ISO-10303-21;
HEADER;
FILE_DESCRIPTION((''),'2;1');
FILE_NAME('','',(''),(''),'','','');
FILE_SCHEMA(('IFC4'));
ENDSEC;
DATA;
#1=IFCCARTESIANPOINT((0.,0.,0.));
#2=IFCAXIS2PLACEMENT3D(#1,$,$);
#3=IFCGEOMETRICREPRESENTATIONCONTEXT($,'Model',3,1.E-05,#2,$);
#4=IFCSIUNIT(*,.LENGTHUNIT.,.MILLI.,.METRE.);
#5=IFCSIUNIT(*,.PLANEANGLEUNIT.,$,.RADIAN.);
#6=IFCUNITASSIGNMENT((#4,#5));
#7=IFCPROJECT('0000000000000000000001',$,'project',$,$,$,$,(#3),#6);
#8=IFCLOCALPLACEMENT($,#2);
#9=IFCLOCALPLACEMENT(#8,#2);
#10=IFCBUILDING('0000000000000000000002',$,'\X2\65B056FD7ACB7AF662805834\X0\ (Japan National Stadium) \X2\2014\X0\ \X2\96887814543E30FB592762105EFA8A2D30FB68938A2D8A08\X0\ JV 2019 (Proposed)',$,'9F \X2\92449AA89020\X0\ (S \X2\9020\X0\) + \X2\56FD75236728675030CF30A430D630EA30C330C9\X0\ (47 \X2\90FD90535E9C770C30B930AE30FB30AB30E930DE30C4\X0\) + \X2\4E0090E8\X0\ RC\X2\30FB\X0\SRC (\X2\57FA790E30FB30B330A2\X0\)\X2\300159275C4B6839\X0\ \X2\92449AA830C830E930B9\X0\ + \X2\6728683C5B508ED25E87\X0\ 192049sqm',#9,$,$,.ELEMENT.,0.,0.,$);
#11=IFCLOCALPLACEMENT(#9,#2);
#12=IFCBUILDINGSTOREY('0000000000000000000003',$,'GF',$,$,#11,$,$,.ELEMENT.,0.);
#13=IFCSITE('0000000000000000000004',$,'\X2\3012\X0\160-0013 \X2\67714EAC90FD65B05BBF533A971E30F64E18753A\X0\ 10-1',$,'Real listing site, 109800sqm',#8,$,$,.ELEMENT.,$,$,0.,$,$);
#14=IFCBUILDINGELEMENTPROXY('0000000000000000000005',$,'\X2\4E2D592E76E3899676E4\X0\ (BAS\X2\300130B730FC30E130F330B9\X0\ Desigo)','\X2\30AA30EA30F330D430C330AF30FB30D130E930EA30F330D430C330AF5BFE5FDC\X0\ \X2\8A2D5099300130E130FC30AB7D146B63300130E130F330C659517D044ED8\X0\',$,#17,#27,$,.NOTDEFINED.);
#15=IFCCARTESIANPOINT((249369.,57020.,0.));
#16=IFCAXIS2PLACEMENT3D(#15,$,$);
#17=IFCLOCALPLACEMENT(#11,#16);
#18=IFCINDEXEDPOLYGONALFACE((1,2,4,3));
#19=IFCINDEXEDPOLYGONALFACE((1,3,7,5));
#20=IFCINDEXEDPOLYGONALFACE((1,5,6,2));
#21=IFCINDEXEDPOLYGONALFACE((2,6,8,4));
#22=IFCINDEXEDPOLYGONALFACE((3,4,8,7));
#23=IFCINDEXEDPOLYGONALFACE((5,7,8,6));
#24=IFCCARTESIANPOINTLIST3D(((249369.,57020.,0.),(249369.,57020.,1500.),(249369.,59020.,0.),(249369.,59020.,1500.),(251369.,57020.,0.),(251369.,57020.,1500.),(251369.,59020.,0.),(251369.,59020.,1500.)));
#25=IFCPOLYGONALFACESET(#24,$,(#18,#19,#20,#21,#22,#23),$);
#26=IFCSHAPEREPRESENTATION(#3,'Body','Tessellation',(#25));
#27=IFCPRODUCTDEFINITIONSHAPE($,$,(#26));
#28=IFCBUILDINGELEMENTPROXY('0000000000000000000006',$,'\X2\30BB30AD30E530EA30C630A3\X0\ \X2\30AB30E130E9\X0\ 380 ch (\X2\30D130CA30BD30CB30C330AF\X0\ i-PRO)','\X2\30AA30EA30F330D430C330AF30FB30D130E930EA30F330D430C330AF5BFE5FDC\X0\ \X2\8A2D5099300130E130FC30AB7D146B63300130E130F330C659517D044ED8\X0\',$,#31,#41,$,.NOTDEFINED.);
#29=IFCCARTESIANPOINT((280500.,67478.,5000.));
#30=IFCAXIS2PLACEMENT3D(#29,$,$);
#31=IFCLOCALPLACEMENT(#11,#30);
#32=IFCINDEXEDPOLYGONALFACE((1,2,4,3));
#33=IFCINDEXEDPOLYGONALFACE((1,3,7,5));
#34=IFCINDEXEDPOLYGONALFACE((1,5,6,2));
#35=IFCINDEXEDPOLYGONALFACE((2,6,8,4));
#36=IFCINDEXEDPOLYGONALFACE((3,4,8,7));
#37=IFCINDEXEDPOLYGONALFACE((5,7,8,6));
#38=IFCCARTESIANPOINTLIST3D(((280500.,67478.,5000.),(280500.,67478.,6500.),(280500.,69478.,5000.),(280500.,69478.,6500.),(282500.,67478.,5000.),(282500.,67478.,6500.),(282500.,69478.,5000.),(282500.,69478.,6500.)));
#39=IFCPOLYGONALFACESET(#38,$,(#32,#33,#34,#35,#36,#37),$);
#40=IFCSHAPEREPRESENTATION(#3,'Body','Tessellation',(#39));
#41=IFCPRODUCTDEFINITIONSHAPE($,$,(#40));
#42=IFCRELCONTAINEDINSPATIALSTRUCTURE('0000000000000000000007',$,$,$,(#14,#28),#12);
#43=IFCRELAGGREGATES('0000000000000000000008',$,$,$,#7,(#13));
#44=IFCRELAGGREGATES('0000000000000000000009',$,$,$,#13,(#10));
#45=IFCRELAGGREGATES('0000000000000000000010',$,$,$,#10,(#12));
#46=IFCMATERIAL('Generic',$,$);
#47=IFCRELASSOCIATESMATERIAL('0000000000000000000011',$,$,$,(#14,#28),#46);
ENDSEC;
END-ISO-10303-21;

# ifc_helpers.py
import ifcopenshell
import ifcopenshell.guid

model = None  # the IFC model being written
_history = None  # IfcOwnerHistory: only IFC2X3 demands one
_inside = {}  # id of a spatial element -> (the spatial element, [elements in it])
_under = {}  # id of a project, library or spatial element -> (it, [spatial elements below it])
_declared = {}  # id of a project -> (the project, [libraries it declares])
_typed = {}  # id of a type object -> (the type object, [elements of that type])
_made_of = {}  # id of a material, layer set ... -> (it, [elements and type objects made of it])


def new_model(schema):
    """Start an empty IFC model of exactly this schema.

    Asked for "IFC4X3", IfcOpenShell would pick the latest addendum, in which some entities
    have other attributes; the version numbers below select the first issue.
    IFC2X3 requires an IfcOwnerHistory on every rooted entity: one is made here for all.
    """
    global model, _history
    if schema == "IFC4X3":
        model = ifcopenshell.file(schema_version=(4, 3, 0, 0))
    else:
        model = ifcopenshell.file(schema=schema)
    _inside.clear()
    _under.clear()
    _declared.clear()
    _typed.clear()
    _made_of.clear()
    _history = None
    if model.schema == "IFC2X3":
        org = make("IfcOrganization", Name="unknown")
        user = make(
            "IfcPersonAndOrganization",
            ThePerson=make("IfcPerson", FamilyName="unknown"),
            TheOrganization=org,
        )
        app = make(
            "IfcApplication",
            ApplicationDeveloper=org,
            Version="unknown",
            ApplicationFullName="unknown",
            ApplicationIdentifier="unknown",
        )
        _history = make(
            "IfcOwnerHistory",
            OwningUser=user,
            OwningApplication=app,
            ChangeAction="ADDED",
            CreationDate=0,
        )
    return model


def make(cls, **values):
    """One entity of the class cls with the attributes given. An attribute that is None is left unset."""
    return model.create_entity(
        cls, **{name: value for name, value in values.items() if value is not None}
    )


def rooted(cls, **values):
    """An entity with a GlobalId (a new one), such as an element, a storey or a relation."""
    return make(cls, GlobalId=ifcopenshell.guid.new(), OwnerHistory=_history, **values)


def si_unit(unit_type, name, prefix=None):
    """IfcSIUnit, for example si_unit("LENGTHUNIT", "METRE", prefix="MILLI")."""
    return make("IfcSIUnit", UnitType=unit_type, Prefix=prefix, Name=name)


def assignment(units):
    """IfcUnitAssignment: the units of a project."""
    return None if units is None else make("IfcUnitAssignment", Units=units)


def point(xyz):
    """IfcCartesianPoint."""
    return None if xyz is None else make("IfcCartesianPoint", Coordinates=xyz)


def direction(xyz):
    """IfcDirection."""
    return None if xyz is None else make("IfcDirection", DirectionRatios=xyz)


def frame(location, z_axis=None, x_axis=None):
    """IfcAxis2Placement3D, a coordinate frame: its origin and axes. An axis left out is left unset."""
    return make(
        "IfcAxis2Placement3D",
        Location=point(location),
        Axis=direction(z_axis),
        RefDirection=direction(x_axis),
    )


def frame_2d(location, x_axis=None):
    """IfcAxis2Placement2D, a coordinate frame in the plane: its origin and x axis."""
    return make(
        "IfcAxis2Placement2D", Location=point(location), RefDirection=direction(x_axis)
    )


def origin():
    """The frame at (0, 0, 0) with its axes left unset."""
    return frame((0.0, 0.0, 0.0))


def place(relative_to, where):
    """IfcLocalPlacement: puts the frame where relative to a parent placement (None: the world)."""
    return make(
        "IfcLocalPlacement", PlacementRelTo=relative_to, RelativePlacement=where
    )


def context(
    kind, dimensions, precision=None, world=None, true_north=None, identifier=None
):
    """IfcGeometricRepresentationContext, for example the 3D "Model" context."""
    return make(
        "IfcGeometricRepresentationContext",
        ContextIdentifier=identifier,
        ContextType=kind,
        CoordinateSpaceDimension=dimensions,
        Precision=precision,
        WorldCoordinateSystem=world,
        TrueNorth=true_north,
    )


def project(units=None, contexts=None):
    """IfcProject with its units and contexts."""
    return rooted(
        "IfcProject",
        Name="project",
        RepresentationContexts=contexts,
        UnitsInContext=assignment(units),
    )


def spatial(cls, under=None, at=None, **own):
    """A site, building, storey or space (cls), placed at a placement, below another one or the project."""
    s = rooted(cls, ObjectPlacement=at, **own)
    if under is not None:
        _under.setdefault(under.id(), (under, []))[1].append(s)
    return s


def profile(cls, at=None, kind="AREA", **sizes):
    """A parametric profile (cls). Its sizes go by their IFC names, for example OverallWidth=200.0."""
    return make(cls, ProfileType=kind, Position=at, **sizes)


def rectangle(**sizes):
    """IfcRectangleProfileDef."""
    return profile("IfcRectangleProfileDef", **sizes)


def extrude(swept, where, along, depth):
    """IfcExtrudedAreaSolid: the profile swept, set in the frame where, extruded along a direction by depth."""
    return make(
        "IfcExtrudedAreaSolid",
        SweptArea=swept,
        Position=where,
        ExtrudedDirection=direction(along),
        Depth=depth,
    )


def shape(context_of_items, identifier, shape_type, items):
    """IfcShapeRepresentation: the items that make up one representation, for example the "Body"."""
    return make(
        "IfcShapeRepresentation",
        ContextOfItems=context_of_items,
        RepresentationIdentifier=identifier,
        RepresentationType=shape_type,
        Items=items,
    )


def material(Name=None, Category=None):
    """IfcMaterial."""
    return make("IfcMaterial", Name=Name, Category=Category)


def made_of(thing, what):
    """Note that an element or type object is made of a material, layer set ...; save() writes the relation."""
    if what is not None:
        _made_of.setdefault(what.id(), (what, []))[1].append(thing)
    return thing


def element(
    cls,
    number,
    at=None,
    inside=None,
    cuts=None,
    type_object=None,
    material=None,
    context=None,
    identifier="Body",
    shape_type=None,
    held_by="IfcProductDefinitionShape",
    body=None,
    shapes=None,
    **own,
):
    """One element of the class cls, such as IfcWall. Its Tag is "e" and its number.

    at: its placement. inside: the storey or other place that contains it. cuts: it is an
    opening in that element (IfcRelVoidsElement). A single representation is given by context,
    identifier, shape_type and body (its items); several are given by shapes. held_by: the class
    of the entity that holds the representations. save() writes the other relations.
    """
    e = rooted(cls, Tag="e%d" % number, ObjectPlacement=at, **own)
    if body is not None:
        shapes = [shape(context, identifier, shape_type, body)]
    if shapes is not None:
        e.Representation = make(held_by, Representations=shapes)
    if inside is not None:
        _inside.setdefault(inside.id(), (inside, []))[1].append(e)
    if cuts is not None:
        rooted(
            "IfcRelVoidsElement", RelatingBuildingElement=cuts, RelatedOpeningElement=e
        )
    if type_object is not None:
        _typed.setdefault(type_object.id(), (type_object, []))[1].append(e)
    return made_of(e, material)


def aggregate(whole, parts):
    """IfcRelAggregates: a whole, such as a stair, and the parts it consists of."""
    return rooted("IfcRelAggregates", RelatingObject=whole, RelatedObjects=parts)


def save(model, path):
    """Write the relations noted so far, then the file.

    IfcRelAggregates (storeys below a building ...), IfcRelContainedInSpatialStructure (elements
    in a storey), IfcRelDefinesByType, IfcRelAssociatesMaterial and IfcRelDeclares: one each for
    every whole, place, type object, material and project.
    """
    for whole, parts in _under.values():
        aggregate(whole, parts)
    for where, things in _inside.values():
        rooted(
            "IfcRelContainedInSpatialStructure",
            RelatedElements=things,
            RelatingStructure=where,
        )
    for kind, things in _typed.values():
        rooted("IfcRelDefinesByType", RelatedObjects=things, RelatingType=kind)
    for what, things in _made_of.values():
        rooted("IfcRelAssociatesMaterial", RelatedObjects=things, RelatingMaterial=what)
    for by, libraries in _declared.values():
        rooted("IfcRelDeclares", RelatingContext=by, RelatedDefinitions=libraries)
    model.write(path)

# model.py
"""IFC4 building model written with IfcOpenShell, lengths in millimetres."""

from ifc_helpers import new_model, si_unit, frame, frame_2d, origin, place, context, project, spatial, rectangle, extrude, material, element, save


model = new_model("IFC4")

# Units and contexts
model_context = context("Model", 3, precision=1e-05, world=origin())
ifc_project = project(units=[si_unit("LENGTHUNIT", "METRE", prefix="MILLI"), si_unit("PLANEANGLEUNIT", "RADIAN")], contexts=[model_context])

# Site, building, storey
site_placement = place(None, origin())
site = spatial("IfcSite", under=ifc_project, at=site_placement, Name="〒160-0013 東京都新宿区霞ヶ丘町 10-1", ObjectType="Real listing site, 109800sqm", CompositionType="ELEMENT", RefElevation=0.0)
building_placement = place(site_placement, origin())
building = spatial("IfcBuilding", under=site, at=building_placement, Name="新国立競技場 (Japan National Stadium) — 隈研吾・大成建設・梓設計 JV 2019 (Proposed)", ObjectType="9F 鉄骨造 (S 造) + 国産木材ハイブリッド (47 都道府県スギ・カラマツ) + 一部 RC・SRC (基礎・コア)、大屋根 鉄骨トラス + 木格子軒庇 192049sqm", CompositionType="ELEMENT", ElevationOfRefHeight=0.0, ElevationOfTerrain=0.0)
storey_placement = place(building_placement, origin())
storey = spatial("IfcBuildingStorey", under=building, at=storey_placement, Name="GF", CompositionType="ELEMENT", Elevation=0.0)

# Shared definitions
ifc_material_1 = material(Name="Generic")

# Building element proxies
proxy_1_placement = place(storey_placement, frame((249369.0, 57020.0, 0.0)))
element("IfcBuildingElementProxy", 1, at=proxy_1_placement, inside=storey, material=ifc_material_1, Name="中央監視盤 (BAS、シーメンス Desigo)", Description="オリンピック・パラリンピック対応 設備、メーカ純正、メンテ契約付", PredefinedType="NOTDEFINED", context=model_context, shape_type="SweptSolid", body=[
    extrude(rectangle(XDim=2000.0, YDim=2000.0, at=frame_2d((1000.0, 1000.0))), frame((249369.0, 57020.0, 0.0)), (0.0, 0.0, 1.0), 1500.0),
])
proxy_2_placement = place(storey_placement, frame((280500.0, 67478.0, 5000.0)))
element("IfcBuildingElementProxy", 2, at=proxy_2_placement, inside=storey, material=ifc_material_1, Name="セキュリティ カメラ 380 ch (パナソニック i-PRO)", Description="オリンピック・パラリンピック対応 設備、メーカ純正、メンテ契約付", PredefinedType="NOTDEFINED", context=model_context, shape_type="SweptSolid", body=[
    extrude(rectangle(XDim=2000.0, YDim=2000.0, at=frame_2d((1000.0, 1000.0))), frame((280500.0, 67478.0, 5000.0)), (0.0, 0.0, 1.0), 1500.0),
])

save(model, "model.ifc")
